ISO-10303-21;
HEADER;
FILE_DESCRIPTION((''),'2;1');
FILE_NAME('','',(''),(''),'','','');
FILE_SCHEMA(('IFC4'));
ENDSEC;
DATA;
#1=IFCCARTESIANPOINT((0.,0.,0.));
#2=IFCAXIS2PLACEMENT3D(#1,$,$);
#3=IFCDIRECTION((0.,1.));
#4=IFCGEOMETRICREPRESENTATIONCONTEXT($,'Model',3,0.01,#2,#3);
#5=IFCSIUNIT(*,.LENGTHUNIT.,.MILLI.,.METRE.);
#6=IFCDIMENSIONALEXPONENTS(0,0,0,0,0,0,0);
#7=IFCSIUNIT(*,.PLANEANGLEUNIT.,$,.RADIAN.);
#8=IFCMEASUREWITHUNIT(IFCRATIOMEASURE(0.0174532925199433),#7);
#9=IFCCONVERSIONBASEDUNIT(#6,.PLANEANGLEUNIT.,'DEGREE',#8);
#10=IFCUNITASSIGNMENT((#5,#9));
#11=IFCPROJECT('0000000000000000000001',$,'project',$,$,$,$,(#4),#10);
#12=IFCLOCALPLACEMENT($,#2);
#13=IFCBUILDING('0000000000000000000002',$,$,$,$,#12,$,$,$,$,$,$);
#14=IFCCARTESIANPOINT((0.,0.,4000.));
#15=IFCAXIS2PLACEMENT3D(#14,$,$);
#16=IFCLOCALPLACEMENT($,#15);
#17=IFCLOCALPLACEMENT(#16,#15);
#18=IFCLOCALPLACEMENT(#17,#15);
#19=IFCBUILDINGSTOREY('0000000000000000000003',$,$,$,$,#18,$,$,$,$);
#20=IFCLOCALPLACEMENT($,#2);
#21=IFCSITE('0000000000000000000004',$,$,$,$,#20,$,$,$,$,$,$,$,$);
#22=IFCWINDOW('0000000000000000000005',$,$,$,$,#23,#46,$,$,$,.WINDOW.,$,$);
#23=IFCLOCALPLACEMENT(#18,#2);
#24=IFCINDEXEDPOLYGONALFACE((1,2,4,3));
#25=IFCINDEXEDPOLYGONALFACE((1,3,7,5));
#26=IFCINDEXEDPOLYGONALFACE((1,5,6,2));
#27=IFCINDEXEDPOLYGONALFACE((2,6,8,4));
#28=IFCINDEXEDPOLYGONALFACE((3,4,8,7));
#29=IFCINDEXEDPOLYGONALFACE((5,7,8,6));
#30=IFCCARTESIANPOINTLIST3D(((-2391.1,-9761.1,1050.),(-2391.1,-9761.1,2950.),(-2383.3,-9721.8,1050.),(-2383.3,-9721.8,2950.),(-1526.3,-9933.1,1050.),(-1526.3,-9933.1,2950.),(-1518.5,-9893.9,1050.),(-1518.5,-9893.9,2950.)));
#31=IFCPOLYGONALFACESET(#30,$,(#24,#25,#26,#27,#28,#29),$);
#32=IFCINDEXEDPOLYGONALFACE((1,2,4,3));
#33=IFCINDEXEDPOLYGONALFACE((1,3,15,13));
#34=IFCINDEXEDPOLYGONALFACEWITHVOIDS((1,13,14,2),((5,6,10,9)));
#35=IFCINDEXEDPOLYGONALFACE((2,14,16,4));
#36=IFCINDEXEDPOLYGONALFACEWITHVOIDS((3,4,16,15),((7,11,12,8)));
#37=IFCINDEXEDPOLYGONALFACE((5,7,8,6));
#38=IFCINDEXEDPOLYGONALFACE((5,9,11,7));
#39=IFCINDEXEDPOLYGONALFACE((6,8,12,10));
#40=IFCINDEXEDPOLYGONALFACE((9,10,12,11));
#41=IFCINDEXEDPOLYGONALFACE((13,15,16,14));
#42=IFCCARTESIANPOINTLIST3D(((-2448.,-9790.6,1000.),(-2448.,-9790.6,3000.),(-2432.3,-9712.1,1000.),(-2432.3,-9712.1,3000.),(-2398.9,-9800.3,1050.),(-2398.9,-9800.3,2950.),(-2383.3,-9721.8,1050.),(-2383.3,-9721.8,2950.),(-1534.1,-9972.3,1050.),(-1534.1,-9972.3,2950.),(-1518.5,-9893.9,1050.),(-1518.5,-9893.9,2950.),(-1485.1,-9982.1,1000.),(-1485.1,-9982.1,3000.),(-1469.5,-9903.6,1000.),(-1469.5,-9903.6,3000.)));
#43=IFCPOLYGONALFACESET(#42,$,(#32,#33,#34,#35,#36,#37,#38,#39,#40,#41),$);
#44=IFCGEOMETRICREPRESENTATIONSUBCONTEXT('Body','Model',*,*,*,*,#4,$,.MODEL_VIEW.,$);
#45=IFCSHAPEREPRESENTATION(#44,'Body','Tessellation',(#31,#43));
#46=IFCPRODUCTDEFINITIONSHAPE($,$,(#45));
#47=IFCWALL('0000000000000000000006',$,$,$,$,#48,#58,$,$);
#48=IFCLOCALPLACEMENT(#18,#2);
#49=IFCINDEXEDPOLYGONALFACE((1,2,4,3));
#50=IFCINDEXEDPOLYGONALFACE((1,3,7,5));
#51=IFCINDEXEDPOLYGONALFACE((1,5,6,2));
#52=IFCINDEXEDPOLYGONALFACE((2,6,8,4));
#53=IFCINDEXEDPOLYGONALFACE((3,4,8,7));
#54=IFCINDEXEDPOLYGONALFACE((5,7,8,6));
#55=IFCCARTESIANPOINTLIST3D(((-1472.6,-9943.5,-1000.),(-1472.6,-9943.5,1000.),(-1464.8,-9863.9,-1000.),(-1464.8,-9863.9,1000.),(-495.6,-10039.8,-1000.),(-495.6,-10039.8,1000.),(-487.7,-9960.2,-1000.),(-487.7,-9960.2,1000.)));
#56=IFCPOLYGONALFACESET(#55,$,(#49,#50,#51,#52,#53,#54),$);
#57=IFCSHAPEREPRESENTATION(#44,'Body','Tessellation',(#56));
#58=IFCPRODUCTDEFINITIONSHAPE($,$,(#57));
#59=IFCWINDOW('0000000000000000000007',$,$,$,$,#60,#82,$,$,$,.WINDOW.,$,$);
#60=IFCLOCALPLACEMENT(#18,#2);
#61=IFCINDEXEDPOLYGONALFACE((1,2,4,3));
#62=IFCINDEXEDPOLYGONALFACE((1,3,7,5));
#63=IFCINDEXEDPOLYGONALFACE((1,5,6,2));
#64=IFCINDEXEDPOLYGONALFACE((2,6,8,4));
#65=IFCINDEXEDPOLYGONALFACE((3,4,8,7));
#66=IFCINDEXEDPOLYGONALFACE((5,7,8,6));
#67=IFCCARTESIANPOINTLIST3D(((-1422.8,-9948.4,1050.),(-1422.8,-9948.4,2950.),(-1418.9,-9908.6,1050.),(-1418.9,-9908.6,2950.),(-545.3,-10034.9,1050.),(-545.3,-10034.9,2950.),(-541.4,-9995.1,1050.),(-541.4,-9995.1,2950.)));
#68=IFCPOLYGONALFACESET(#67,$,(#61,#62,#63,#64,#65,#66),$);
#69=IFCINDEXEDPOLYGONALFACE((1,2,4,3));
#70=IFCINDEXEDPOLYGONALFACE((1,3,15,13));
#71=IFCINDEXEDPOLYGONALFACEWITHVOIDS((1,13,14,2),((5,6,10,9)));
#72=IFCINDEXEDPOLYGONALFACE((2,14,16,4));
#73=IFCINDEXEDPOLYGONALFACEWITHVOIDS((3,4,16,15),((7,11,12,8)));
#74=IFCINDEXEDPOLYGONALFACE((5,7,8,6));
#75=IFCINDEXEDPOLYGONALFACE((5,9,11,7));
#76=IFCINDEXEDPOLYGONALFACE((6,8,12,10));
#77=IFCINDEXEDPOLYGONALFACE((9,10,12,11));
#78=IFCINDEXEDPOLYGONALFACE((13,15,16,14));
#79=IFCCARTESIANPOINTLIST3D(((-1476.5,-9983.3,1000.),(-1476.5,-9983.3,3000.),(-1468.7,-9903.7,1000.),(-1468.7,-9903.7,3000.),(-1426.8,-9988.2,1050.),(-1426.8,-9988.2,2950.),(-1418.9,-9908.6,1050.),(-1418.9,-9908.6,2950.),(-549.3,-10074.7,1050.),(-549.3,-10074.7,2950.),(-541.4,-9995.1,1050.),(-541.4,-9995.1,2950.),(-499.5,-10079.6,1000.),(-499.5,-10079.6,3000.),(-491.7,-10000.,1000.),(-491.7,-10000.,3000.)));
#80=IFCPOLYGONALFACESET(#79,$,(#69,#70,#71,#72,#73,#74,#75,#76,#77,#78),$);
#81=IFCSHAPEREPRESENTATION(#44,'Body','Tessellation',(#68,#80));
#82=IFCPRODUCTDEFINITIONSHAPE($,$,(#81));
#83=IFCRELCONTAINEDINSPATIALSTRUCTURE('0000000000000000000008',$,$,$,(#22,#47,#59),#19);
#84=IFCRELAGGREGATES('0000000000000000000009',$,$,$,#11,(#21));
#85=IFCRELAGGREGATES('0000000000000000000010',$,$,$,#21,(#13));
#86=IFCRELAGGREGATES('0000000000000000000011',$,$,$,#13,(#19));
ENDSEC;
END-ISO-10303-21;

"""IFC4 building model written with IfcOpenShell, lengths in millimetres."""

from ifc_helpers import new_model, entity, si_unit, converted_unit, direction, frame, origin, origin_2d, place, context, subcontext, project, spatial, rectangle, extrude, element, save


model = new_model("IFC4")

# Units and contexts
model_context = context("Model", 3, precision=0.01, world=origin(), true_north=direction((0.0, 1.0)))
body_context = subcontext(model_context, "Body", "Model", "MODEL_VIEW")
ifc_project = project(units=[si_unit("LENGTHUNIT", "METRE", prefix="MILLI"), converted_unit("PLANEANGLEUNIT", "DEGREE", entity("IfcRatioMeasure", 0.0174532925199433), si_unit("PLANEANGLEUNIT", "RADIAN"), dimensions=[0, 0, 0, 0, 0, 0, 0])], contexts=[model_context])

# Site, building, storey
site_placement = place(None, origin())
site = spatial("IfcSite", under=ifc_project, at=site_placement)
building_placement = place(None, origin())
building = spatial("IfcBuilding", under=site, at=building_placement)
placement_1 = place(None, frame((0.0, 0.0, 4000.0)))
placement_2 = place(placement_1, frame((0.0, 0.0, 4000.0)))
storey_placement = place(placement_2, frame((0.0, 0.0, 4000.0)))
storey = spatial("IfcBuildingStorey", under=building, at=storey_placement)

# Shared definitions
cartesian_point_1 = entity("IfcCartesianPoint", [-440.9, -950.0])
shared_polyline = entity("IfcPolyline", [cartesian_point_1, entity("IfcCartesianPoint", [-440.9, 950.0]), entity("IfcCartesianPoint", [-440.9, 950.0]), entity("IfcCartesianPoint", [440.9, 950.0]), entity("IfcCartesianPoint", [440.9, 950.0]), entity("IfcCartesianPoint", [440.9, -950.0]), entity("IfcCartesianPoint", [440.9, -950.0]), entity("IfcCartesianPoint", [-440.9, -950.0]), cartesian_point_1])

# Window
window_1_placement = place(storey_placement, frame((-1950.9, -9807.9, 2000.0), z_axis=(0.0, 0.0, 1.0), x_axis=(9807.852671, -1950.903888, 0.0)))
cartesian_point_2 = entity("IfcCartesianPoint", [-490.9, -1000.0])
element("IfcWindow", 1, at=window_1_placement, inside=storey, PredefinedType="WINDOW", context=body_context, shape_type="SweptSolid", body=[
    entity("IfcExtrudedAreaSolid", entity("IfcArbitraryClosedProfileDef", "AREA", None, shared_polyline), entity("IfcAxis2Placement3D", entity("IfcCartesianPoint", [0.0, 0.0, 0.0]), entity("IfcDirection", [0.0, -1.0, 0.0]), entity("IfcDirection", [1.0, 0.0, 0.0])), entity("IfcDirection", [0.0, 0.0, 1.0]), 40.0),
    entity("IfcExtrudedAreaSolid", entity("IfcArbitraryProfileDefWithVoids", "AREA", None, entity("IfcPolyline", [cartesian_point_2, entity("IfcCartesianPoint", [-490.9, 1000.0]), entity("IfcCartesianPoint", [-490.9, 1000.0]), entity("IfcCartesianPoint", [490.9, 1000.0]), entity("IfcCartesianPoint", [490.9, 1000.0]), entity("IfcCartesianPoint", [490.9, -1000.0]), entity("IfcCartesianPoint", [490.9, -1000.0]), entity("IfcCartesianPoint", [-490.9, -1000.0]), cartesian_point_2]), [shared_polyline]), entity("IfcAxis2Placement3D", entity("IfcCartesianPoint", [0.0, 0.0, 0.0]), entity("IfcDirection", [0.0, -1.0, 0.0]), entity("IfcDirection", [1.0, 0.0, 0.0])), entity("IfcDirection", [0.0, 0.0, 1.0]), 80.0),
])

# Wall
wall_1_placement = place(storey_placement, frame((-980.2, -9951.8, -1000.0), z_axis=(0.0, 0.0, 1.0), x_axis=(9951.847473, -980.16931, 0.0)))
element("IfcWall", 2, at=wall_1_placement, inside=storey, context=body_context, shape_type="SweptSolid", body=[
    extrude(rectangle(XDim=981.7, YDim=80.0, at=origin_2d()), origin(), (0.0, 0.0, 1.0), 2000.0),
])

# Window
window_2_placement = place(storey_placement, frame((-980.2, -9951.8, 2000.0), z_axis=(0.0, 0.0, 1.0), x_axis=(9951.847473, -980.16931, 0.0)))
cartesian_point_3 = entity("IfcCartesianPoint", [-490.9, -1000.0])
element("IfcWindow", 3, at=window_2_placement, inside=storey, PredefinedType="WINDOW", context=body_context, shape_type="SweptSolid", body=[
    entity("IfcExtrudedAreaSolid", entity("IfcArbitraryClosedProfileDef", "AREA", None, shared_polyline), entity("IfcAxis2Placement3D", entity("IfcCartesianPoint", [0.0, 0.0, 0.0]), entity("IfcDirection", [0.0, -1.0, 0.0]), entity("IfcDirection", [1.0, 0.0, 0.0])), entity("IfcDirection", [0.0, 0.0, 1.0]), 40.0),
    entity("IfcExtrudedAreaSolid", entity("IfcArbitraryProfileDefWithVoids", "AREA", None, entity("IfcPolyline", [cartesian_point_3, entity("IfcCartesianPoint", [-490.9, 1000.0]), entity("IfcCartesianPoint", [-490.9, 1000.0]), entity("IfcCartesianPoint", [490.9, 1000.0]), entity("IfcCartesianPoint", [490.9, 1000.0]), entity("IfcCartesianPoint", [490.9, -1000.0]), entity("IfcCartesianPoint", [490.9, -1000.0]), entity("IfcCartesianPoint", [-490.9, -1000.0]), cartesian_point_3]), [shared_polyline]), entity("IfcAxis2Placement3D", entity("IfcCartesianPoint", [0.0, 0.0, 0.0]), entity("IfcDirection", [0.0, -1.0, 0.0]), entity("IfcDirection", [1.0, 0.0, 0.0])), entity("IfcDirection", [0.0, 0.0, 1.0]), 80.0),
])

save(model, "model.ifc")
